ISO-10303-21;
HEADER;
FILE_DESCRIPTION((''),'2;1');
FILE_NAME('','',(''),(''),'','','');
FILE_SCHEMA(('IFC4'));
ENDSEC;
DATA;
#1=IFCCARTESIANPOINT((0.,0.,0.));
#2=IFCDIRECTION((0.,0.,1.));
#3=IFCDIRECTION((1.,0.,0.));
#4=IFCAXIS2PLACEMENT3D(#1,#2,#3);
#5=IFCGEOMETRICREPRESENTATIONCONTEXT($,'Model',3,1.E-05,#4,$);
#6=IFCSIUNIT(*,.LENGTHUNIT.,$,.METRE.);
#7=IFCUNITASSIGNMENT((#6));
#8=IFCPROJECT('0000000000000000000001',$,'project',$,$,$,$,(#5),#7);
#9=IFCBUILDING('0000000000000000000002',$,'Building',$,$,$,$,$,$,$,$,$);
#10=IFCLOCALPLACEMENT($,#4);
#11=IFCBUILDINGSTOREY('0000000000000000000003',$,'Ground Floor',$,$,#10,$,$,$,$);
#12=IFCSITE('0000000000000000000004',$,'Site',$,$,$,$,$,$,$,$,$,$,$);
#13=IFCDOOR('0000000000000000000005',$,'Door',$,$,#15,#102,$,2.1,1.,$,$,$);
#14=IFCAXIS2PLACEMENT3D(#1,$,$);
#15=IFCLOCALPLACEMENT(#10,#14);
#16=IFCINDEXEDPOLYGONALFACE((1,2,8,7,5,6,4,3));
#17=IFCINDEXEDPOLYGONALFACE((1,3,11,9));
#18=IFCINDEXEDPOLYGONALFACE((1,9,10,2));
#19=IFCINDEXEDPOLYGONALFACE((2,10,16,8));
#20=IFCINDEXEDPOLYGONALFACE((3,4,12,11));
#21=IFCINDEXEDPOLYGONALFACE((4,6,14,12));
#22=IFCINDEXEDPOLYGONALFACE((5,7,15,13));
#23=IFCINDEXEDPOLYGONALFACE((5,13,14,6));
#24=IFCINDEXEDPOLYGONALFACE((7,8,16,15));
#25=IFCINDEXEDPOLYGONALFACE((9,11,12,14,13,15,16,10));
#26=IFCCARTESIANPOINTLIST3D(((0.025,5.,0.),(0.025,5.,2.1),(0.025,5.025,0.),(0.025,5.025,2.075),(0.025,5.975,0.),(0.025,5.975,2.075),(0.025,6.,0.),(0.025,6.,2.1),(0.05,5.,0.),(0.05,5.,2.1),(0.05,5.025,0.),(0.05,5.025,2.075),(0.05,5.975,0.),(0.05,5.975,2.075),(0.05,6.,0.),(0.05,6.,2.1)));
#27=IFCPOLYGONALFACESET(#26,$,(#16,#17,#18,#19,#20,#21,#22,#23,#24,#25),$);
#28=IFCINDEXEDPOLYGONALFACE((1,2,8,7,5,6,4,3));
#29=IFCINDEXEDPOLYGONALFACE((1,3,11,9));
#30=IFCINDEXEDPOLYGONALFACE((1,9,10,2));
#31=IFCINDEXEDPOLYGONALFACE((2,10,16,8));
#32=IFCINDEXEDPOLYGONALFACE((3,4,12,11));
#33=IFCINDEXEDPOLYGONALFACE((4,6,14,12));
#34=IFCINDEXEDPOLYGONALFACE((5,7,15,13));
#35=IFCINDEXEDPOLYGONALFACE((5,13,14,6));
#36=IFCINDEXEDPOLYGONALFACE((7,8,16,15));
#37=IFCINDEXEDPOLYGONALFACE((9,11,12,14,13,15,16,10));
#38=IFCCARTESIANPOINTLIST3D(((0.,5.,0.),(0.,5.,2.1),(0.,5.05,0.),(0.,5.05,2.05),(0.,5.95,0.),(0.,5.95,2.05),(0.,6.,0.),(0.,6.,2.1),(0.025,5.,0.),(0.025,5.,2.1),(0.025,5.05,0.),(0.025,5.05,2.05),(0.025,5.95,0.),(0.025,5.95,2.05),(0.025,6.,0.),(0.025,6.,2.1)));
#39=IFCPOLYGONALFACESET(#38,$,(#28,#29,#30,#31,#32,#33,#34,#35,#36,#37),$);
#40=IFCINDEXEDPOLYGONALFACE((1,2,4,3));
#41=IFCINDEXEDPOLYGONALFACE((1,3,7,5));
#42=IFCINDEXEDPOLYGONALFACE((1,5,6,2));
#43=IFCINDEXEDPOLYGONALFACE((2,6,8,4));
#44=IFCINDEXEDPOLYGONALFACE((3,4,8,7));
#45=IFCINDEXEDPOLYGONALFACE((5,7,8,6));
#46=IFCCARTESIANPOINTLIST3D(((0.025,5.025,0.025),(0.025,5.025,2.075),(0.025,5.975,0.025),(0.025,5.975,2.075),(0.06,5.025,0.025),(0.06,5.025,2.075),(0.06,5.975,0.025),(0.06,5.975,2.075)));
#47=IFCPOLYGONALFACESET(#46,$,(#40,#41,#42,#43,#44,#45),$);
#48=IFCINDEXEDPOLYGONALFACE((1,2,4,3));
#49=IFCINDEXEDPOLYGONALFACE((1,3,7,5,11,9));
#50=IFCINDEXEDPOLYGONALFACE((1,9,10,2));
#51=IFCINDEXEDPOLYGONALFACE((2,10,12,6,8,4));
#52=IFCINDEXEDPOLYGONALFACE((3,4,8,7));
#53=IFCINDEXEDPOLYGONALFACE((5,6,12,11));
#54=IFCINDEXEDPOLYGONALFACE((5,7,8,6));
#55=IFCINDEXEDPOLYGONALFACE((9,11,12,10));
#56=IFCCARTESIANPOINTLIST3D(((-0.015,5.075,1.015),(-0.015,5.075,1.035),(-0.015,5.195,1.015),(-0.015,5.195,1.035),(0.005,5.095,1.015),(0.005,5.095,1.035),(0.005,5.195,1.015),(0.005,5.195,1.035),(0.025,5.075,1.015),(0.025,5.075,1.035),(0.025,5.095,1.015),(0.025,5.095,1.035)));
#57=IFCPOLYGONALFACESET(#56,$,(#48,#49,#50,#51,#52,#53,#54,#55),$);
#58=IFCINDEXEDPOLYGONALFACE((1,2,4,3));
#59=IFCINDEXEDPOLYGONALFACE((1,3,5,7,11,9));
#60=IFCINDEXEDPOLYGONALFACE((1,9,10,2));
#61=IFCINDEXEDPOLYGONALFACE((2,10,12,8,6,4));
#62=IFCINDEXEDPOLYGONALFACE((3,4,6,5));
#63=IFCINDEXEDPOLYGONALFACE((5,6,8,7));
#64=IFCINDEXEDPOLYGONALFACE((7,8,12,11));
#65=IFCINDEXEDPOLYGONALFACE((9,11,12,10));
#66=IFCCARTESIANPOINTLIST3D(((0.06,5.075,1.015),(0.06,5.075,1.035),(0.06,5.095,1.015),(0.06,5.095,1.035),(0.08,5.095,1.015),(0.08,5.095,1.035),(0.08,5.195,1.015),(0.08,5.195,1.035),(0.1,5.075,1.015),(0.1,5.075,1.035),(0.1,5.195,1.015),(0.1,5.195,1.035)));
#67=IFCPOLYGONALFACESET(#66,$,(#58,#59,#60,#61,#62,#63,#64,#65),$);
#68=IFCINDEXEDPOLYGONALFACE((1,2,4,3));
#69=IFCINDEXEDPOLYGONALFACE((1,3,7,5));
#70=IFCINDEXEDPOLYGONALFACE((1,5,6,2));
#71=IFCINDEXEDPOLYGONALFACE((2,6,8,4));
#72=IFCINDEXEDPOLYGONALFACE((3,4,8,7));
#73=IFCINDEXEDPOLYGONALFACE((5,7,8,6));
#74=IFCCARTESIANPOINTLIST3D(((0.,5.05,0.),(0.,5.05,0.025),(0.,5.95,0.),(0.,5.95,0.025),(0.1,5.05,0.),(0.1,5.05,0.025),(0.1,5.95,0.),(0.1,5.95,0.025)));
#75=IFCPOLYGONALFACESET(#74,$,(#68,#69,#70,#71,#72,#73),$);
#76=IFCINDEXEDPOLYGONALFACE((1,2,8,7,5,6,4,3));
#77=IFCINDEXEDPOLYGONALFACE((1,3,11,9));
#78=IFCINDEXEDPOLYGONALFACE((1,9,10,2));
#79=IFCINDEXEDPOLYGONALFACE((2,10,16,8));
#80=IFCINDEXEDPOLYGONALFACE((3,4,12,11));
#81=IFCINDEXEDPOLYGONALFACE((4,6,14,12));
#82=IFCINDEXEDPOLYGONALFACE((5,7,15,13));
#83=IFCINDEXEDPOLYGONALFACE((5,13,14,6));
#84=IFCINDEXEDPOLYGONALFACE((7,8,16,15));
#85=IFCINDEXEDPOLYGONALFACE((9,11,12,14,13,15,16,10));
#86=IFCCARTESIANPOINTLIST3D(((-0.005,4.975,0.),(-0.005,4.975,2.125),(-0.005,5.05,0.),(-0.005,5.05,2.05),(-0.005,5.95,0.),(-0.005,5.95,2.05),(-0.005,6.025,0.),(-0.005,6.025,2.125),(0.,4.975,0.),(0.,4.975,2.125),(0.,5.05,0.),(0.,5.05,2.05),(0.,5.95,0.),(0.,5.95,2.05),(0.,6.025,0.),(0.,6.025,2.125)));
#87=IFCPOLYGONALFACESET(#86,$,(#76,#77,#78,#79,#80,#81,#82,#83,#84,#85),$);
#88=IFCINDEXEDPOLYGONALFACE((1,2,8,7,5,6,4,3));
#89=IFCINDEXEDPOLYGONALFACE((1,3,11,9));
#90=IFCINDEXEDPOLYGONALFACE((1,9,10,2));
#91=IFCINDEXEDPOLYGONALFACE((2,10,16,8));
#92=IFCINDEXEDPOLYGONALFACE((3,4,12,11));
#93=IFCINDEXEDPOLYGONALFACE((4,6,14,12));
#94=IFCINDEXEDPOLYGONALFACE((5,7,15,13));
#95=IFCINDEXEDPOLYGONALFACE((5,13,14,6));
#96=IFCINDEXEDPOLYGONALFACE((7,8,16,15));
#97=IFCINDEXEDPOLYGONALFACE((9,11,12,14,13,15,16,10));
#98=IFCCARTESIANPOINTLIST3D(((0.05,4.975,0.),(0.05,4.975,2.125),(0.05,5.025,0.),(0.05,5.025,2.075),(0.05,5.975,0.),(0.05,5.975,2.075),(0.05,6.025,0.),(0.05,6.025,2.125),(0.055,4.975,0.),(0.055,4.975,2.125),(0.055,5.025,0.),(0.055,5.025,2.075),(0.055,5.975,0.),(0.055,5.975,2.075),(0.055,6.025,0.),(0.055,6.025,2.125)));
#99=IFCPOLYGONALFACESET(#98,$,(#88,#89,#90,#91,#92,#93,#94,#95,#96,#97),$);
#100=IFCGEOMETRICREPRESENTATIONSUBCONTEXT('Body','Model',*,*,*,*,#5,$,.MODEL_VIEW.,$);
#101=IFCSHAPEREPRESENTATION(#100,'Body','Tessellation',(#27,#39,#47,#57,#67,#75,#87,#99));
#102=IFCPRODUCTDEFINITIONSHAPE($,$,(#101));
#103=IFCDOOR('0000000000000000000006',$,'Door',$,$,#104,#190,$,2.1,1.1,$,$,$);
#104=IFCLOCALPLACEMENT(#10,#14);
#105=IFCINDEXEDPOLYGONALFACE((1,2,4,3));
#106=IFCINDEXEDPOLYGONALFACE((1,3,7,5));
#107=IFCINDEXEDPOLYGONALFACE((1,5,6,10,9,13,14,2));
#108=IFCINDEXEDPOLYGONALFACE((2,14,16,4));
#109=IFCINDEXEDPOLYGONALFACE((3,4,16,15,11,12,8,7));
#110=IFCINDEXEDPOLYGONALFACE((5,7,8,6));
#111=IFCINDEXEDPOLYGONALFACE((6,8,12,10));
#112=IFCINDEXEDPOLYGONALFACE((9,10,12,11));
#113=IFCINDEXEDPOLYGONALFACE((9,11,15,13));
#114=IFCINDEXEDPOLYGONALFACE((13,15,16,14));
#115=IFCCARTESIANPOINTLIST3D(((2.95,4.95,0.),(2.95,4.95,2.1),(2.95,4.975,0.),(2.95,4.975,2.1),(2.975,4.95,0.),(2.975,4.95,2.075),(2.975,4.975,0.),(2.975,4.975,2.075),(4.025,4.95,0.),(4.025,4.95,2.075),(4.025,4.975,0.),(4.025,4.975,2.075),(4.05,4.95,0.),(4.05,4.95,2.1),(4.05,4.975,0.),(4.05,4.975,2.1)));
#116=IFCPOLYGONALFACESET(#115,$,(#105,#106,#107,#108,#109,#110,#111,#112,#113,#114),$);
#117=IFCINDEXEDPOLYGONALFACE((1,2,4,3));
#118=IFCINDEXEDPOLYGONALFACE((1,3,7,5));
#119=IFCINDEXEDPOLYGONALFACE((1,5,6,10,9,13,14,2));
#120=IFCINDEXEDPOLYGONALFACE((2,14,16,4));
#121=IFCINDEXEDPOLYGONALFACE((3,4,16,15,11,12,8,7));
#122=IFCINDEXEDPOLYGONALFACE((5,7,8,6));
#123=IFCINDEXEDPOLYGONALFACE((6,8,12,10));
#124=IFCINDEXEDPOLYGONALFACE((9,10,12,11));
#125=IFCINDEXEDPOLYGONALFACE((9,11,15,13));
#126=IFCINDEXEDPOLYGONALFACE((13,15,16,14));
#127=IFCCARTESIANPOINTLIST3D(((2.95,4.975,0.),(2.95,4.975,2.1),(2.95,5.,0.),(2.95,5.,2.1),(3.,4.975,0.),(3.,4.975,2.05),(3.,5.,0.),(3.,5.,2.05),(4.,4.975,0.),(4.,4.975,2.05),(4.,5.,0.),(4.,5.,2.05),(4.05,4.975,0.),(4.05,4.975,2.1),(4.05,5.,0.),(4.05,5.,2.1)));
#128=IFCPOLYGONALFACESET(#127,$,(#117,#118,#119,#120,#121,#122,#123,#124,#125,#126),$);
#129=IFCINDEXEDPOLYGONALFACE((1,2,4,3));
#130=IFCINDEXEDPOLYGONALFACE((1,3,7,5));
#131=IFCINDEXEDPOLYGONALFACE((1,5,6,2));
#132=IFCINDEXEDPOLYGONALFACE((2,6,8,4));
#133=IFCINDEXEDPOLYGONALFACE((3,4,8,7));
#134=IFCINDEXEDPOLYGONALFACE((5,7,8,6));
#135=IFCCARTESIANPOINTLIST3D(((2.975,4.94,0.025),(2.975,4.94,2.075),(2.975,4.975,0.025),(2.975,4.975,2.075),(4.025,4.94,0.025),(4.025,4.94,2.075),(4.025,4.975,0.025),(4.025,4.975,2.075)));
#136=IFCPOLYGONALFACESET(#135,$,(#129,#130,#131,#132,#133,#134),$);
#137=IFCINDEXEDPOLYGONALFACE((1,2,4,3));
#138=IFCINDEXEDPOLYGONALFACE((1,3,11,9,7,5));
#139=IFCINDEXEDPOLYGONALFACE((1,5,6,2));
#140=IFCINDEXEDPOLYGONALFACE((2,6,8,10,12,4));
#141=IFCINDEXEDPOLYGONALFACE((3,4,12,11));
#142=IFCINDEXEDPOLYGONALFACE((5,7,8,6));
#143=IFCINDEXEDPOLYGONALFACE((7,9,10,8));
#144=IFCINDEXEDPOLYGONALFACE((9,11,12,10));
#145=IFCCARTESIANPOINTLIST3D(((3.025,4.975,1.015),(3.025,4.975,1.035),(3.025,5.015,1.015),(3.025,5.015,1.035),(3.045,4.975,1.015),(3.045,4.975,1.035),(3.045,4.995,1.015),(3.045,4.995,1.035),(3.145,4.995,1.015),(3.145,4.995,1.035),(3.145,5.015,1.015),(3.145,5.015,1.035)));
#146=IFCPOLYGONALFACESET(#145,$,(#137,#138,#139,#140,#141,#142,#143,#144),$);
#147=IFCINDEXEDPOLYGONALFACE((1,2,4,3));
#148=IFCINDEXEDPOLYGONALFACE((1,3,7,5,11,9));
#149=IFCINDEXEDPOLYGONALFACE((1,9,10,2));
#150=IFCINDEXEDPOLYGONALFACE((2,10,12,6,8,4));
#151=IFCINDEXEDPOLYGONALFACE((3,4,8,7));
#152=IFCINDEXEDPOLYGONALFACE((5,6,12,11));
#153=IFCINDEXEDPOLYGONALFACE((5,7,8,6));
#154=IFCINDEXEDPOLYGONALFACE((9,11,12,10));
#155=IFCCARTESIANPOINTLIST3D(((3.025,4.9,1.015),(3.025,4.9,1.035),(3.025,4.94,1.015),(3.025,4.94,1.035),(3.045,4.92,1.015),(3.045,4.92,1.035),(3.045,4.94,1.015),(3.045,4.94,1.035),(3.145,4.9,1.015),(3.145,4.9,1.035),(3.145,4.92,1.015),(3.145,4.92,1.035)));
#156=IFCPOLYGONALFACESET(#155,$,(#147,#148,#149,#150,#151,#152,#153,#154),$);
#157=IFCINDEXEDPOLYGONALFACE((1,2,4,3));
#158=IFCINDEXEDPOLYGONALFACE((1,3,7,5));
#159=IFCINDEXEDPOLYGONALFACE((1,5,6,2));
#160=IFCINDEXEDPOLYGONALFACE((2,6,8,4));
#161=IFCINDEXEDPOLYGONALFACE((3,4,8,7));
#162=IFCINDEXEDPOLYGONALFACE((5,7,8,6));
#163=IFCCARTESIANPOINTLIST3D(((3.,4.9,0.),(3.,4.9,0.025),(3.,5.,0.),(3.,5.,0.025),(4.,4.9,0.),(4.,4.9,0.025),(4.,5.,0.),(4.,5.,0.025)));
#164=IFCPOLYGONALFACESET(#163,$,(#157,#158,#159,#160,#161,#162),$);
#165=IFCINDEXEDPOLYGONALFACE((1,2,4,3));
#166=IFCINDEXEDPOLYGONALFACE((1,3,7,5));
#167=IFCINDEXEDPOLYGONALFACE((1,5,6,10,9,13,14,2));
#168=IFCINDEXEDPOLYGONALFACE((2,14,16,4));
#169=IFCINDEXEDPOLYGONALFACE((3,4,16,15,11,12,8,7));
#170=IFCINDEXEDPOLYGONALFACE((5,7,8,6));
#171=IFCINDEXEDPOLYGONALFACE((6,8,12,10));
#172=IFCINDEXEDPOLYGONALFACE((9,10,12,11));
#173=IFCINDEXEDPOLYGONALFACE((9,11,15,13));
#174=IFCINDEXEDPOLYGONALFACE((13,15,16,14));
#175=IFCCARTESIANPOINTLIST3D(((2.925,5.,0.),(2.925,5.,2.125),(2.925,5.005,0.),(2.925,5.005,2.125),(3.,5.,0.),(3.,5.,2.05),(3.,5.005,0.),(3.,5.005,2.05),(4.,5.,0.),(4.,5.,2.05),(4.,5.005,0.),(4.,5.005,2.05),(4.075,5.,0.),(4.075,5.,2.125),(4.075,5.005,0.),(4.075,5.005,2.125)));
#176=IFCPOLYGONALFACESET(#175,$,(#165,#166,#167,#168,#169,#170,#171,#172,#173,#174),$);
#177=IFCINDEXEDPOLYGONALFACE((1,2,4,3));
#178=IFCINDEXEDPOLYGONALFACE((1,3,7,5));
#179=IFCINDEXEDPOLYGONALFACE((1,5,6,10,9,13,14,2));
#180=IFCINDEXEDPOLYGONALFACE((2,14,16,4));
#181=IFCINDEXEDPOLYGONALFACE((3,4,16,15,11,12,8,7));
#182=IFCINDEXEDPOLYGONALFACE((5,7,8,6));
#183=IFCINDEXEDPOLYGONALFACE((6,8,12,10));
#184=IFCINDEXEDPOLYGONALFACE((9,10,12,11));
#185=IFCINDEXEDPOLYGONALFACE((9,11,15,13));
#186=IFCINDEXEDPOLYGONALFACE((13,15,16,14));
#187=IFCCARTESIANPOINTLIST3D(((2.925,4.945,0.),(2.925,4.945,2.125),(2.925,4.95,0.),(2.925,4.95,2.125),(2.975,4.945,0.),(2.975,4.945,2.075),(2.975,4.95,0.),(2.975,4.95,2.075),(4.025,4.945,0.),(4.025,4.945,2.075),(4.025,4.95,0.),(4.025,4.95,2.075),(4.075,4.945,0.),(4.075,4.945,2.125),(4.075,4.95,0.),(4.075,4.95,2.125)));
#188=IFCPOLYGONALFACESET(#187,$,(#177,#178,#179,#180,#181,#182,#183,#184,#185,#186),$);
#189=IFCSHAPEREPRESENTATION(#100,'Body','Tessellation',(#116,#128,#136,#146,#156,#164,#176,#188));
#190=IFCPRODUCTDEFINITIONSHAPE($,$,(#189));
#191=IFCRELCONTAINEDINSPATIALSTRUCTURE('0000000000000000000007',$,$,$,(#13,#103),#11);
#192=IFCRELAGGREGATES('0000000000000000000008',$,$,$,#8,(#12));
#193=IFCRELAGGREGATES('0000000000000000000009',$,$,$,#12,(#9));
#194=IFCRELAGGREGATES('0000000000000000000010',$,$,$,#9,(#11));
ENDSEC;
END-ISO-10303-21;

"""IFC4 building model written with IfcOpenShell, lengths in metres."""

from ifc_helpers import new_model, si_unit, frame, origin_with_axes, place, context, subcontext, project, spatial, line, indexed_curve, outline, extrude, element, save


model = new_model("IFC4")

# Units and contexts
model_context = context("Model", 3, precision=1e-05, world=origin_with_axes())
body_context = subcontext(model_context, "Body", "Model", "MODEL_VIEW")
ifc_project = project(units=[si_unit("LENGTHUNIT", "METRE")], contexts=[model_context])

# Site, building, storey
site = spatial("IfcSite", under=ifc_project, Name="Site")
building = spatial("IfcBuilding", under=site, Name="Building")
storey_placement = place(None, origin_with_axes())
storey = spatial("IfcBuildingStorey", under=building, at=storey_placement, Name="Ground Floor")

# Doors
door_1_placement = place(storey_placement, frame((0.0, 6.0, 0.0), z_axis=(0.0, 0.0, 1.0), x_axis=(0.0, -1.0, 0.0)))
element("IfcDoor", 1, at=door_1_placement, inside=storey, Name="Door", OverallHeight=2.1, OverallWidth=1.0, context=body_context, shape_type="SweptSolid", body=[
    extrude(outline(indexed_curve([(0.0, 0.0), (0.0, 2.1), (1.0, 2.1), (1.0, 0.0), (0.975, 0.0), (0.975, 2.075), (0.025, 2.075), (0.025, 0.0)], segments=[line(1, 2, 3, 4, 5, 6, 7, 8, 1)])), frame((0.0, 0.025, 0.0), z_axis=(0.0, -1.0, 0.0), x_axis=(1.0, 0.0, 0.0)), (0.0, 0.0, -1.0), 0.025),
    extrude(outline(indexed_curve([(0.0, 0.0), (0.0, 2.1), (1.0, 2.1), (1.0, 0.0), (0.95, 0.0), (0.95, 2.05), (0.05, 2.05), (0.05, 0.0)], segments=[line(1, 2, 3, 4, 5, 6, 7, 8, 1)])), frame((0.0, 0.0, 0.0), z_axis=(0.0, -1.0, 0.0), x_axis=(1.0, 0.0, 0.0)), (0.0, 0.0, -1.0), 0.025),
    extrude(outline(indexed_curve([(0.0, 0.0), (0.95, 0.0), (0.95, 0.035), (0.0, 0.035)], segments=[line(1, 2, 3, 4, 1)])), frame((0.025, 0.025, 0.025), z_axis=(0.0, 0.0, 1.0), x_axis=(1.0, 0.0, 0.0)), (0.0, 0.0, 1.0), 2.05),
    extrude(outline(indexed_curve([(0.0, 0.0), (0.0, -0.04), (-0.12, -0.04), (-0.12, -0.02), (-0.02, -0.02), (-0.02, 0.0)], segments=[line(1, 2, 3, 4, 5, 6, 1)])), frame((0.925, 0.025, 1.015), z_axis=(0.0, 0.0, 1.0), x_axis=(1.0, 0.0, 0.0)), (0.0, 0.0, 1.0), 0.02),
    extrude(outline(indexed_curve([(0.0, 0.0), (0.0, 0.04), (-0.12, 0.04), (-0.12, 0.02), (-0.02, 0.02), (-0.02, 0.0)], segments=[line(1, 2, 3, 4, 5, 6, 1)])), frame((0.925, 0.06, 1.015), z_axis=(0.0, 0.0, 1.0), x_axis=(1.0, 0.0, 0.0)), (0.0, 0.0, 1.0), 0.02),
    extrude(outline(indexed_curve([(0.0, 0.0), (0.9, 0.0), (0.9, 0.1), (0.0, 0.1)], segments=[line(1, 2, 3, 4, 1)])), frame((0.05, 0.0, 0.0), z_axis=(0.0, 0.0, 1.0), x_axis=(1.0, 0.0, 0.0)), (0.0, 0.0, 1.0), 0.025),
    extrude(outline(indexed_curve([(0.0, 0.0), (0.0, 2.125), (1.05, 2.125), (1.05, 0.0), (0.975, 0.0), (0.975, 2.05), (0.075, 2.05), (0.075, 0.0)], segments=[line(1, 2, 3, 4, 5, 6, 7, 8, 1)])), frame((-0.025, -0.005, 0.0), z_axis=(0.0, -1.0, 0.0), x_axis=(1.0, 0.0, 0.0)), (0.0, 0.0, -1.0), 0.005),
    extrude(outline(indexed_curve([(0.0, 0.0), (0.0, 2.125), (1.05, 2.125), (1.05, 0.0), (1.0, 0.0), (1.0, 2.075), (0.05, 2.075), (0.05, 0.0)], segments=[line(1, 2, 3, 4, 5, 6, 7, 8, 1)])), frame((-0.025, 0.05, 0.0), z_axis=(0.0, -1.0, 0.0), x_axis=(1.0, 0.0, 0.0)), (0.0, 0.0, -1.0), 0.005),
])
door_2_placement = place(storey_placement, frame((4.05, 5.0, 0.0), z_axis=(0.0, 0.0, 1.0), x_axis=(-1.0, 0.0, 0.0)))
element("IfcDoor", 2, at=door_2_placement, inside=storey, Name="Door", OverallHeight=2.1, OverallWidth=1.1, context=body_context, shape_type="SweptSolid", body=[
    extrude(outline(indexed_curve([(0.0, 0.0), (0.0, 2.1), (1.1, 2.1), (1.1, 0.0), (1.075, 0.0), (1.075, 2.075), (0.025, 2.075), (0.025, 0.0)], segments=[line(1, 2, 3, 4, 5, 6, 7, 8, 1)])), frame((0.0, 0.025, 0.0), z_axis=(0.0, -1.0, 0.0), x_axis=(1.0, 0.0, 0.0)), (0.0, 0.0, -1.0), 0.025),
    extrude(outline(indexed_curve([(0.0, 0.0), (0.0, 2.1), (1.1, 2.1), (1.1, 0.0), (1.05, 0.0), (1.05, 2.05), (0.05, 2.05), (0.05, 0.0)], segments=[line(1, 2, 3, 4, 5, 6, 7, 8, 1)])), frame((0.0, 0.0, 0.0), z_axis=(0.0, -1.0, 0.0), x_axis=(1.0, 0.0, 0.0)), (0.0, 0.0, -1.0), 0.025),
    extrude(outline(indexed_curve([(0.0, 0.0), (1.05, 0.0), (1.05, 0.035), (0.0, 0.035)], segments=[line(1, 2, 3, 4, 1)])), frame((0.025, 0.025, 0.025), z_axis=(0.0, 0.0, 1.0), x_axis=(1.0, 0.0, 0.0)), (0.0, 0.0, 1.0), 2.05),
    extrude(outline(indexed_curve([(0.0, 0.0), (0.0, -0.04), (-0.12, -0.04), (-0.12, -0.02), (-0.02, -0.02), (-0.02, 0.0)], segments=[line(1, 2, 3, 4, 5, 6, 1)])), frame((1.025, 0.025, 1.015), z_axis=(0.0, 0.0, 1.0), x_axis=(1.0, 0.0, 0.0)), (0.0, 0.0, 1.0), 0.02),
    extrude(outline(indexed_curve([(0.0, 0.0), (0.0, 0.04), (-0.12, 0.04), (-0.12, 0.02), (-0.02, 0.02), (-0.02, 0.0)], segments=[line(1, 2, 3, 4, 5, 6, 1)])), frame((1.025, 0.06, 1.015), z_axis=(0.0, 0.0, 1.0), x_axis=(1.0, 0.0, 0.0)), (0.0, 0.0, 1.0), 0.02),
    extrude(outline(indexed_curve([(0.0, 0.0), (1.0, 0.0), (1.0, 0.1), (0.0, 0.1)], segments=[line(1, 2, 3, 4, 1)])), frame((0.05, 0.0, 0.0), z_axis=(0.0, 0.0, 1.0), x_axis=(1.0, 0.0, 0.0)), (0.0, 0.0, 1.0), 0.025),
    extrude(outline(indexed_curve([(0.0, 0.0), (0.0, 2.125), (1.15, 2.125), (1.15, 0.0), (1.075, 0.0), (1.075, 2.05), (0.075, 2.05), (0.075, 0.0)], segments=[line(1, 2, 3, 4, 5, 6, 7, 8, 1)])), frame((-0.025, -0.005, 0.0), z_axis=(0.0, -1.0, 0.0), x_axis=(1.0, 0.0, 0.0)), (0.0, 0.0, -1.0), 0.005),
    extrude(outline(indexed_curve([(0.0, 0.0), (0.0, 2.125), (1.15, 2.125), (1.15, 0.0), (1.1, 0.0), (1.1, 2.075), (0.05, 2.075), (0.05, 0.0)], segments=[line(1, 2, 3, 4, 5, 6, 7, 8, 1)])), frame((-0.025, 0.05, 0.0), z_axis=(0.0, -1.0, 0.0), x_axis=(1.0, 0.0, 0.0)), (0.0, 0.0, -1.0), 0.005),
])

save(model, "model.ifc")
